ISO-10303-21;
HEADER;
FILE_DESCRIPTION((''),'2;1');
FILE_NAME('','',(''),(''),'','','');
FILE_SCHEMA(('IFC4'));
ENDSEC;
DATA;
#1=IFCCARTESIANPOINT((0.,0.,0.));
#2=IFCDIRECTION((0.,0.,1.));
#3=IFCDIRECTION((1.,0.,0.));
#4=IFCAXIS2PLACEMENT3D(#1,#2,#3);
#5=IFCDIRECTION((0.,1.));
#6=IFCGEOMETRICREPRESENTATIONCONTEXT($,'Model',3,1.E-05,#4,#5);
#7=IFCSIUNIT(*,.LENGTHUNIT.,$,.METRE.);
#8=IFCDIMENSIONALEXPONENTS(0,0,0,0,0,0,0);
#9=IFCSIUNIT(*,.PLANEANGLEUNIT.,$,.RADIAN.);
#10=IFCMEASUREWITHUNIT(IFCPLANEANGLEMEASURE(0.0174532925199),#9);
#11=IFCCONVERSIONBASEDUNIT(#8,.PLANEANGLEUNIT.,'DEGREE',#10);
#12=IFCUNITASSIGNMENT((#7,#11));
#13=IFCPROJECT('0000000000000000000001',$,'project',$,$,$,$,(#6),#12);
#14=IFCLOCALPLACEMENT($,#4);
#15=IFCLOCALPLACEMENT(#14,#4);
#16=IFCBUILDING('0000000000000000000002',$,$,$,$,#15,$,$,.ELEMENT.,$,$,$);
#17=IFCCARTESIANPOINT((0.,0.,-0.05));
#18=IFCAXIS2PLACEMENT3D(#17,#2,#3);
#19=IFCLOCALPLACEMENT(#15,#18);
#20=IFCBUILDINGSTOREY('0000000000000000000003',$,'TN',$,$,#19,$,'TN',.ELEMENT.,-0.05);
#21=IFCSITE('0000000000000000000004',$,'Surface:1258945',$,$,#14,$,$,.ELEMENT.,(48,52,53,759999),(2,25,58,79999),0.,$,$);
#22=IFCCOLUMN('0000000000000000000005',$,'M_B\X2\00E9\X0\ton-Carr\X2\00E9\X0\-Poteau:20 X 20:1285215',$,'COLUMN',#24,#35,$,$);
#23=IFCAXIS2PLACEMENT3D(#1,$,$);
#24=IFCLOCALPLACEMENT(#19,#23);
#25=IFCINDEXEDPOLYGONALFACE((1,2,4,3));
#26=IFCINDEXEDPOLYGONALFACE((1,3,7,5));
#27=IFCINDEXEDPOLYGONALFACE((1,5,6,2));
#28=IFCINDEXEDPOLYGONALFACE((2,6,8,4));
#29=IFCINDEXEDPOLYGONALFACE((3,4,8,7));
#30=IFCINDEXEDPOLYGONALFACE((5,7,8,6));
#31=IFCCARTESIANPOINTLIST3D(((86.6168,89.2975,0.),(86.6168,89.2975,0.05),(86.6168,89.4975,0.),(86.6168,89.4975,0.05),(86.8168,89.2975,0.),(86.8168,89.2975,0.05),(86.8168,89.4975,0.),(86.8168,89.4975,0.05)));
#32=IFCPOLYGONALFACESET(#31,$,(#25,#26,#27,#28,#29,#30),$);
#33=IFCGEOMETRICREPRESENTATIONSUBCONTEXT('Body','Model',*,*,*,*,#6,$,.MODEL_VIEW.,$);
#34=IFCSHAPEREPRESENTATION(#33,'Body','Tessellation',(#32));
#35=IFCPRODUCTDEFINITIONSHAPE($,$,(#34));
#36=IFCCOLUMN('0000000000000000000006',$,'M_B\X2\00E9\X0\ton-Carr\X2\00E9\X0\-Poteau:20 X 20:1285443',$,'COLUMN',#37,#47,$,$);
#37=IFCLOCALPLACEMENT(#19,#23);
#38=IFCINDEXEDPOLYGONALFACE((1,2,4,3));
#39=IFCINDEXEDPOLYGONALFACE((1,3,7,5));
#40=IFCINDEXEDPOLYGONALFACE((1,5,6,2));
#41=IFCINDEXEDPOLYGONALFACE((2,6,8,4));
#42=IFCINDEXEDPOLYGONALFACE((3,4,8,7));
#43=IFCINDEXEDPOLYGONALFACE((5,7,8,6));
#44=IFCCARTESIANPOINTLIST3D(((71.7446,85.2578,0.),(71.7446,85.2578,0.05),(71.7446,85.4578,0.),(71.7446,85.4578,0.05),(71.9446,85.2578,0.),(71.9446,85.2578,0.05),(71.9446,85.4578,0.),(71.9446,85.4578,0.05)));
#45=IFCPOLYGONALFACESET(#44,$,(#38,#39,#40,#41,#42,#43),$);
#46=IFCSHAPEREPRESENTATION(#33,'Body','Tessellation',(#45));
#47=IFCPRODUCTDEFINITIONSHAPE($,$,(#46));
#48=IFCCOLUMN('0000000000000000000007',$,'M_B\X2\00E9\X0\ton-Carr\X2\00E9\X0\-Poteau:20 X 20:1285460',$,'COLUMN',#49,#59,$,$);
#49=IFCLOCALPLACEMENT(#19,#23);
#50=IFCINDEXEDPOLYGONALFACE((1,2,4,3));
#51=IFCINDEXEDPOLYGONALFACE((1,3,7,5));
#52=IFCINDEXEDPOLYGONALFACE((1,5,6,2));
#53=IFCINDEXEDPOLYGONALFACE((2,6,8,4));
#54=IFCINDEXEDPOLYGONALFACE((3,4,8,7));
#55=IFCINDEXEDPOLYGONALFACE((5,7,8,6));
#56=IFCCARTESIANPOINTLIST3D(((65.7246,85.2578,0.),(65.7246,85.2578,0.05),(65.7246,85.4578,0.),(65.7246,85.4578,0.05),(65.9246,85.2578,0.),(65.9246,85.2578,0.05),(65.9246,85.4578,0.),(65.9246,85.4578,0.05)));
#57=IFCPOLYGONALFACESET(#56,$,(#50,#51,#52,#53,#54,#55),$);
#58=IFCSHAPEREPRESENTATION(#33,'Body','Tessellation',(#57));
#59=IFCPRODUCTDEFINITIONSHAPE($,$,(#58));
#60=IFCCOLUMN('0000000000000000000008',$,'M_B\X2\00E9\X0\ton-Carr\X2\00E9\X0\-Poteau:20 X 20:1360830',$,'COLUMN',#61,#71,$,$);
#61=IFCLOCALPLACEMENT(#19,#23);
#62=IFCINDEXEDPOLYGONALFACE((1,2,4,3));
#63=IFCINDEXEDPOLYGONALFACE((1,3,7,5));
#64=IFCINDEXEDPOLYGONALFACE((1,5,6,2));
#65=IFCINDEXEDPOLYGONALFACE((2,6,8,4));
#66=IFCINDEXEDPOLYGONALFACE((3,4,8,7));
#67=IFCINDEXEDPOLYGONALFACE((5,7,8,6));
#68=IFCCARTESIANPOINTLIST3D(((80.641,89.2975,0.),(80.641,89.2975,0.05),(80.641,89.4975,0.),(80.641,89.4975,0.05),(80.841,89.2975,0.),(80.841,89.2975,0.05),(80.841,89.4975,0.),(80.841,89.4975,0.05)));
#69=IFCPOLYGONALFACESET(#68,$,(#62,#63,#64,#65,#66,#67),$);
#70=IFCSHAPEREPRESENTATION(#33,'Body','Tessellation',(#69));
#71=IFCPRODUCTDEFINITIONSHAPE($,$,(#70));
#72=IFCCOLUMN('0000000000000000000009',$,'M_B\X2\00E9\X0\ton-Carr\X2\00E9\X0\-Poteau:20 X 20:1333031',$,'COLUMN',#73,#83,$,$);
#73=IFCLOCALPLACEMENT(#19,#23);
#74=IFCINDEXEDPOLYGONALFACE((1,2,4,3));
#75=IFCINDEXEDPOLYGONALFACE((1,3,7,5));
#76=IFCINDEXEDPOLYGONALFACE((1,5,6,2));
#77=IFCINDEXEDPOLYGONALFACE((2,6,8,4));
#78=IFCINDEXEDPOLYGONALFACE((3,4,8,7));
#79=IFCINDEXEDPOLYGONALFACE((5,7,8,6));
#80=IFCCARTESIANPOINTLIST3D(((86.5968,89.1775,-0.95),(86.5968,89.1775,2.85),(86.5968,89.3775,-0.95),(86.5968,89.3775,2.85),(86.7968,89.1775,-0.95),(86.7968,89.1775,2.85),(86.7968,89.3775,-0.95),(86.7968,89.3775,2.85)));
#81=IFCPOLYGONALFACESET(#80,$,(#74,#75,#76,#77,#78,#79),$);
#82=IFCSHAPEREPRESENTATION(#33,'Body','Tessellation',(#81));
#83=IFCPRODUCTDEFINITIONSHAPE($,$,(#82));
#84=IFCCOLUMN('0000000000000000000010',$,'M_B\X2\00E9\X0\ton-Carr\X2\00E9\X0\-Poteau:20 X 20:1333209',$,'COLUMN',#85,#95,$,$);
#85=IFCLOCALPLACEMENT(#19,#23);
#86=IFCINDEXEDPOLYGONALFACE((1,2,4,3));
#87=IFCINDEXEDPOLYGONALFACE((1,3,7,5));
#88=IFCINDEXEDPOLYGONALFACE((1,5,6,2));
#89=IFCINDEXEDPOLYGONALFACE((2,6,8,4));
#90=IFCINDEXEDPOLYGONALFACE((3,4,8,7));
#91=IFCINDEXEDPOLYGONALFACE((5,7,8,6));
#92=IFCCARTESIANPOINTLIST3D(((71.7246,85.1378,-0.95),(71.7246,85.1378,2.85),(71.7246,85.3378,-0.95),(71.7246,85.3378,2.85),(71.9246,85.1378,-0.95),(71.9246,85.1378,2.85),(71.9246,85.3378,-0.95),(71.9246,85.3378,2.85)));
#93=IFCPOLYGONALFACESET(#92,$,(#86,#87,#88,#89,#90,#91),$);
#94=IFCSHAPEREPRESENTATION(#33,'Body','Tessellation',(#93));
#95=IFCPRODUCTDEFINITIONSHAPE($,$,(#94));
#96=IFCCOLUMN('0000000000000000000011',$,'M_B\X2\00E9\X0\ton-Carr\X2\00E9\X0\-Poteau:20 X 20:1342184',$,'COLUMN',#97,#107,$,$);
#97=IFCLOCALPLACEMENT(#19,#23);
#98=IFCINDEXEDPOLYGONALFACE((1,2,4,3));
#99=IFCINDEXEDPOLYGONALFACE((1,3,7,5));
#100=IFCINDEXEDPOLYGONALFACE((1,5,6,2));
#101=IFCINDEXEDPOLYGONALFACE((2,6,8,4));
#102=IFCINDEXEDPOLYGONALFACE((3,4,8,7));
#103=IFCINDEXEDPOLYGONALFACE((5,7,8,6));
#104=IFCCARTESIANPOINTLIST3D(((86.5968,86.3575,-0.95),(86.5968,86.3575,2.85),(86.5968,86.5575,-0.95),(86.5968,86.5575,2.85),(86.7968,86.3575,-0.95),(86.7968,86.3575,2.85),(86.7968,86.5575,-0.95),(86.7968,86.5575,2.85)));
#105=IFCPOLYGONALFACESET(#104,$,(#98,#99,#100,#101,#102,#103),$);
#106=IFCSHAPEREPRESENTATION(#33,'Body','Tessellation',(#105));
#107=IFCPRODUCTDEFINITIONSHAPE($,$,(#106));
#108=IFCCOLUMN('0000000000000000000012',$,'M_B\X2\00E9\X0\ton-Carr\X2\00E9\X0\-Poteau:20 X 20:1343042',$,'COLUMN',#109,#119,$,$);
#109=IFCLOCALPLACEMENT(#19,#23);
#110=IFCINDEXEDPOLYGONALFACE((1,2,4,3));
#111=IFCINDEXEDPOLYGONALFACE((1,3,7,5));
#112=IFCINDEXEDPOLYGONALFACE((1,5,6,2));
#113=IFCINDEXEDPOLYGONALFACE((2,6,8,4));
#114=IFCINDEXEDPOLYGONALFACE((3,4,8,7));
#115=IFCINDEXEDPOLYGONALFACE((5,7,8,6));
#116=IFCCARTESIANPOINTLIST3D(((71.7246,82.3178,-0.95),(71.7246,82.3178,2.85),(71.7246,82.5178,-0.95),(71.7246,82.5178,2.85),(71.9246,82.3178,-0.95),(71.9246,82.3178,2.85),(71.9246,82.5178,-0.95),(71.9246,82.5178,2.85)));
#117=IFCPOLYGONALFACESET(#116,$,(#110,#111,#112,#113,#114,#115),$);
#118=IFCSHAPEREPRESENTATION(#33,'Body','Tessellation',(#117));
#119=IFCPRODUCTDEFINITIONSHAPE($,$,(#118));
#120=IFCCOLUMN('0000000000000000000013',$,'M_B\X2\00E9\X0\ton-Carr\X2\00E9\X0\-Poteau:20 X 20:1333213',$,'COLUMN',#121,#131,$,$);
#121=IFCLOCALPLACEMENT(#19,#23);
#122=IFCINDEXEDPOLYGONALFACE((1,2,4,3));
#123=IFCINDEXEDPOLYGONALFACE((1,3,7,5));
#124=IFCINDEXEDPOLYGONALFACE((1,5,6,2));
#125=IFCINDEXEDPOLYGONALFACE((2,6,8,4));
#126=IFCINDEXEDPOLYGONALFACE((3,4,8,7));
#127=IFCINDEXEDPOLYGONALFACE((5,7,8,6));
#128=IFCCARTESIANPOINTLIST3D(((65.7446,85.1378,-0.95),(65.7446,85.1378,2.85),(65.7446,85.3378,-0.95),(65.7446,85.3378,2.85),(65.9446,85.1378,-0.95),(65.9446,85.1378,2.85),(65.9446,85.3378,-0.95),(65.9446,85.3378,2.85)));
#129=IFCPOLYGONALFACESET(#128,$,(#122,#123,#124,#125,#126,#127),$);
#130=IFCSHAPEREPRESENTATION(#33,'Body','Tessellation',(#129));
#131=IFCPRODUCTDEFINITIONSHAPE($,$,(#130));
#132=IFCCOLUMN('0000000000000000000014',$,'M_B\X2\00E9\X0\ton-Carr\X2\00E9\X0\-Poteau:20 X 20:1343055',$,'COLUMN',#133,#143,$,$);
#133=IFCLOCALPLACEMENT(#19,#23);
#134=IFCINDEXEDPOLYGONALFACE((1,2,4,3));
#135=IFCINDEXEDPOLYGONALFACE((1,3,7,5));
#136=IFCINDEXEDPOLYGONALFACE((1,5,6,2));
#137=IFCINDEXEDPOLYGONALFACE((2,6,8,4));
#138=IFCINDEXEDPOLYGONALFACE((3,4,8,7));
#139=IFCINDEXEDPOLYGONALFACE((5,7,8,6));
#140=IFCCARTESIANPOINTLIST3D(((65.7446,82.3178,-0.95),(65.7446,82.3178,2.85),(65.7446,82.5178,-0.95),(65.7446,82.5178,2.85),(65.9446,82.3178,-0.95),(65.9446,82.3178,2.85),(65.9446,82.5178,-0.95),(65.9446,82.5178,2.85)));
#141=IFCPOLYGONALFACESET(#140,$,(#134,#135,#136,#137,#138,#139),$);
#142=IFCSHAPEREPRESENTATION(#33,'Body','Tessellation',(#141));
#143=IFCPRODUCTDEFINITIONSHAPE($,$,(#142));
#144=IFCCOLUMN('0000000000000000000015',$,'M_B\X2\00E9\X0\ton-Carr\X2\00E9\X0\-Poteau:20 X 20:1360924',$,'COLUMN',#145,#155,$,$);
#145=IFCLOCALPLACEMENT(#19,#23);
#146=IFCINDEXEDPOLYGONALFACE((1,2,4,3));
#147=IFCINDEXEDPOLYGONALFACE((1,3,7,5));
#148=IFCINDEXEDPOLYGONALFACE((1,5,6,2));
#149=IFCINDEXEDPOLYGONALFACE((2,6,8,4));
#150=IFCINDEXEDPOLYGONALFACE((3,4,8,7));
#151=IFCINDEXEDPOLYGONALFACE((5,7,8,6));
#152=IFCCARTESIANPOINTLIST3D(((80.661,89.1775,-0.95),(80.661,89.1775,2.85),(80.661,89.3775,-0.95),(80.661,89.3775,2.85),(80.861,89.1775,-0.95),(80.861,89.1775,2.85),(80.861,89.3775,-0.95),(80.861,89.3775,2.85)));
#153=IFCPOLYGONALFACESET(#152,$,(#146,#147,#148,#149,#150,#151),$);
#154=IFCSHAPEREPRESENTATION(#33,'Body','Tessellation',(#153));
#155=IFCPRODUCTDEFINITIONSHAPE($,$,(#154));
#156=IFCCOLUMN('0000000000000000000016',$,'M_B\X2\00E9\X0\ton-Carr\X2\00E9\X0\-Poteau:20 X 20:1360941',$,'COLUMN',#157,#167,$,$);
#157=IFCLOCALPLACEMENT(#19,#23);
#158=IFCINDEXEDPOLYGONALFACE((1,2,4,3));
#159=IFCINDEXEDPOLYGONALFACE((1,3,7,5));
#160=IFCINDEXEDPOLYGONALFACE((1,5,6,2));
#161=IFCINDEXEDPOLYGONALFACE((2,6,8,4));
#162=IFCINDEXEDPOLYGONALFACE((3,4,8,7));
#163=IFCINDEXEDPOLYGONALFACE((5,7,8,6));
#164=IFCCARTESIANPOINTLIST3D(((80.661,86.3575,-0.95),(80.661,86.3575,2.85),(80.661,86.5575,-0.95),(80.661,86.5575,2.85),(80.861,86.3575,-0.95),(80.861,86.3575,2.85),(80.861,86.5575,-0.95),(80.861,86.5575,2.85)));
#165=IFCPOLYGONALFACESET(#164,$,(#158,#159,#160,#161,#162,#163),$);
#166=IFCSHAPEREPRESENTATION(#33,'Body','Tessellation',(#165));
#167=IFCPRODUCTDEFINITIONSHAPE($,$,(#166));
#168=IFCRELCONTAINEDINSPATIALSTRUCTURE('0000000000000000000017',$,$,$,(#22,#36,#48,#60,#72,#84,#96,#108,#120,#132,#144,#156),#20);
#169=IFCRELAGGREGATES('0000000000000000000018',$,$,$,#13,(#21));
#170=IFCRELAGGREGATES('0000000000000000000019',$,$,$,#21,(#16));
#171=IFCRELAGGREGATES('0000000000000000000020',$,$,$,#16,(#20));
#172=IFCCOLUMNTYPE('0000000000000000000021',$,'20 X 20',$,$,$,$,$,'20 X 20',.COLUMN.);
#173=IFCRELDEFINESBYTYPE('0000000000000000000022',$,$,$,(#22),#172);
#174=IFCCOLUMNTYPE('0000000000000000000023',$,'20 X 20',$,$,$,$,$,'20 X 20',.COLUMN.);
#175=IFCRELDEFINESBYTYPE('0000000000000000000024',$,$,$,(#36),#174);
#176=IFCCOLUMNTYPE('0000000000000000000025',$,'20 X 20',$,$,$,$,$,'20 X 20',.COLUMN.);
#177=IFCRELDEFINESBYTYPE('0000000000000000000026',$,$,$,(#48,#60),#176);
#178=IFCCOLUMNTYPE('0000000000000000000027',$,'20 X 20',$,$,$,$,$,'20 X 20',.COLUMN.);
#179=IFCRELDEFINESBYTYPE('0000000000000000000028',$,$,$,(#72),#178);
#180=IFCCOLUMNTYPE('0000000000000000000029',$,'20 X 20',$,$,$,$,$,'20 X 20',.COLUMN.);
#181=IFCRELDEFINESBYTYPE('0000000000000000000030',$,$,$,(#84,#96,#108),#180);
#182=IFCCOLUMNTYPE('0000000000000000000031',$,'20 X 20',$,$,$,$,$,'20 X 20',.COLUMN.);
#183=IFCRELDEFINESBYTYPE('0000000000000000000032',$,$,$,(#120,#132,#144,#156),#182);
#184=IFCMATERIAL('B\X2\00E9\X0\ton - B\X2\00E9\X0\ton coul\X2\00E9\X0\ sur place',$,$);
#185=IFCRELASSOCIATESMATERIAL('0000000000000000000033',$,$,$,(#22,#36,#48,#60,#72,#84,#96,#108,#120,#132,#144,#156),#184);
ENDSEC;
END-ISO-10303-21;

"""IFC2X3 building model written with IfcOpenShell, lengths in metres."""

from ifc_helpers import new_model, entity, si_unit, converted_unit, direction, frame, origin_with_axes, origin_2d_with_axis, place, context, subcontext, project, spatial, rectangle, extrude, material, type_object, element, save


model = new_model("IFC2X3")

# Units and contexts
model_context = context("Model", 3, precision=1e-05, world=origin_with_axes(), true_north=direction((0.0, 1.0)))
body_context = subcontext(model_context, "Body", "Model", "MODEL_VIEW")
ifc_project = project(units=[si_unit("LENGTHUNIT", "METRE"), converted_unit("PLANEANGLEUNIT", "DEGREE", entity("IfcPlaneAngleMeasure", 0.0174532925199), si_unit("PLANEANGLEUNIT", "RADIAN"), dimensions=[0, 0, 0, 0, 0, 0, 0])], contexts=[model_context])

# Site, building, storey
site_placement = place(None, origin_with_axes())
site = spatial("IfcSite", under=ifc_project, at=site_placement, Name="Surface:1258945", CompositionType="ELEMENT", RefLatitude=(48, 52, 53, 759999), RefLongitude=(2, 25, 58, 79999), RefElevation=0.0)
building_placement = place(site_placement, origin_with_axes())
building = spatial("IfcBuilding", under=site, at=building_placement, CompositionType="ELEMENT")
storey_placement = place(building_placement, frame((0.0, 0.0, -0.05), z_axis=(0.0, 0.0, 1.0), x_axis=(1.0, 0.0, 0.0)))
storey = spatial("IfcBuildingStorey", under=building, at=storey_placement, Name="TN", LongName="TN", CompositionType="ELEMENT", Elevation=-0.05)

# Columns
ifc_material = material(Name="Béton - Béton coulé sur place")
column_type_1 = type_object("IfcColumnType", Name="20 X 20", ElementType="20 X 20", PredefinedType="COLUMN")
column_1_placement = place(storey_placement, frame((86.7168, 89.3975, 0.0), z_axis=(0.0, 0.0, 1.0), x_axis=(-1.0, 0.0, 0.0)))
element("IfcColumn", 1, at=column_1_placement, inside=storey, type_object=column_type_1, material=ifc_material, Name="M_Béton-Carré-Poteau:20 X 20:1285215", ObjectType="COLUMN", context=body_context, shape_type="SweptSolid", body=[
    extrude(rectangle(XDim=0.2, YDim=0.2, at=origin_2d_with_axis()), origin_with_axes(), (0.0, 0.0, 1.0), 0.05),
])
column_type_2 = type_object("IfcColumnType", Name="20 X 20", ElementType="20 X 20", PredefinedType="COLUMN")
column_2_placement = place(storey_placement, frame((71.8446, 85.3578, 0.0), z_axis=(0.0, 0.0, 1.0), x_axis=(-1.0, 0.0, 0.0)))
element("IfcColumn", 2, at=column_2_placement, inside=storey, type_object=column_type_2, material=ifc_material, Name="M_Béton-Carré-Poteau:20 X 20:1285443", ObjectType="COLUMN", context=body_context, shape_type="SweptSolid", body=[
    extrude(rectangle(XDim=0.2, YDim=0.2, at=origin_2d_with_axis()), origin_with_axes(), (0.0, 0.0, 1.0), 0.05),
])
column_type_3 = type_object("IfcColumnType", Name="20 X 20", ElementType="20 X 20", PredefinedType="COLUMN")
for number, where, z_axis, x_axis, name in (
    (3, (65.8246, 85.3578, 0.0), (0.0, 0.0, 1.0), (0.0, -1.0, 0.0), "M_Béton-Carré-Poteau:20 X 20:1285460"),
    (4, (80.741, 89.3975, 0.0), (0.0, 0.0, 1.0), (0.0, -1.0, 0.0), "M_Béton-Carré-Poteau:20 X 20:1360830"),
):
    element("IfcColumn", number, at=place(storey_placement, frame(where, z_axis=z_axis, x_axis=x_axis)), inside=storey, type_object=column_type_3, material=ifc_material, Name=name, ObjectType="COLUMN", context=body_context, shape_type="SweptSolid", body=[
        extrude(rectangle(XDim=0.2, YDim=0.2, at=origin_2d_with_axis()), origin_with_axes(), (0.0, 0.0, 1.0), 0.05),
    ])
column_type_4 = type_object("IfcColumnType", Name="20 X 20", ElementType="20 X 20", PredefinedType="COLUMN")
column_3_placement = place(storey_placement, frame((86.6968, 89.2775, -0.95), z_axis=(0.0, 0.0, 1.0), x_axis=(-1.0, 0.0, 0.0)))
element("IfcColumn", 5, at=column_3_placement, inside=storey, type_object=column_type_4, material=ifc_material, Name="M_Béton-Carré-Poteau:20 X 20:1333031", ObjectType="COLUMN", context=body_context, shape_type="SweptSolid", body=[
    extrude(rectangle(XDim=0.2, YDim=0.2, at=origin_2d_with_axis()), origin_with_axes(), (0.0, 0.0, 1.0), 3.8),
])
column_type_5 = type_object("IfcColumnType", Name="20 X 20", ElementType="20 X 20", PredefinedType="COLUMN")
for number, where, z_axis, x_axis, name in (
    (6, (71.8246, 85.2378, -0.95), (0.0, 0.0, 1.0), (-1.0, 0.0, 0.0), "M_Béton-Carré-Poteau:20 X 20:1333209"),
    (7, (86.6968, 86.4575, -0.95), (0.0, 0.0, 1.0), (-1.0, 0.0, 0.0), "M_Béton-Carré-Poteau:20 X 20:1342184"),
    (8, (71.8246, 82.4178, -0.95), (0.0, 0.0, 1.0), (-1.0, 0.0, 0.0), "M_Béton-Carré-Poteau:20 X 20:1343042"),
):
    element("IfcColumn", number, at=place(storey_placement, frame(where, z_axis=z_axis, x_axis=x_axis)), inside=storey, type_object=column_type_5, material=ifc_material, Name=name, ObjectType="COLUMN", context=body_context, shape_type="SweptSolid", body=[
        extrude(rectangle(XDim=0.2, YDim=0.2, at=origin_2d_with_axis()), origin_with_axes(), (0.0, 0.0, 1.0), 3.8),
    ])
column_type_6 = type_object("IfcColumnType", Name="20 X 20", ElementType="20 X 20", PredefinedType="COLUMN")
for number, where, z_axis, x_axis, name in (
    (9, (65.8446, 85.2378, -0.95), (0.0, 0.0, 1.0), (0.0, -1.0, 0.0), "M_Béton-Carré-Poteau:20 X 20:1333213"),
    (10, (65.8446, 82.4178, -0.95), (0.0, 0.0, 1.0), (0.0, -1.0, 0.0), "M_Béton-Carré-Poteau:20 X 20:1343055"),
    (11, (80.761, 89.2775, -0.95), (0.0, 0.0, 1.0), (0.0, -1.0, 0.0), "M_Béton-Carré-Poteau:20 X 20:1360924"),
    (12, (80.761, 86.4575, -0.95), (0.0, 0.0, 1.0), (0.0, -1.0, 0.0), "M_Béton-Carré-Poteau:20 X 20:1360941"),
):
    element("IfcColumn", number, at=place(storey_placement, frame(where, z_axis=z_axis, x_axis=x_axis)), inside=storey, type_object=column_type_6, material=ifc_material, Name=name, ObjectType="COLUMN", context=body_context, shape_type="SweptSolid", body=[
        extrude(rectangle(XDim=0.2, YDim=0.2, at=origin_2d_with_axis()), origin_with_axes(), (0.0, 0.0, 1.0), 3.8),
    ])

save(model, "model.ifc")
